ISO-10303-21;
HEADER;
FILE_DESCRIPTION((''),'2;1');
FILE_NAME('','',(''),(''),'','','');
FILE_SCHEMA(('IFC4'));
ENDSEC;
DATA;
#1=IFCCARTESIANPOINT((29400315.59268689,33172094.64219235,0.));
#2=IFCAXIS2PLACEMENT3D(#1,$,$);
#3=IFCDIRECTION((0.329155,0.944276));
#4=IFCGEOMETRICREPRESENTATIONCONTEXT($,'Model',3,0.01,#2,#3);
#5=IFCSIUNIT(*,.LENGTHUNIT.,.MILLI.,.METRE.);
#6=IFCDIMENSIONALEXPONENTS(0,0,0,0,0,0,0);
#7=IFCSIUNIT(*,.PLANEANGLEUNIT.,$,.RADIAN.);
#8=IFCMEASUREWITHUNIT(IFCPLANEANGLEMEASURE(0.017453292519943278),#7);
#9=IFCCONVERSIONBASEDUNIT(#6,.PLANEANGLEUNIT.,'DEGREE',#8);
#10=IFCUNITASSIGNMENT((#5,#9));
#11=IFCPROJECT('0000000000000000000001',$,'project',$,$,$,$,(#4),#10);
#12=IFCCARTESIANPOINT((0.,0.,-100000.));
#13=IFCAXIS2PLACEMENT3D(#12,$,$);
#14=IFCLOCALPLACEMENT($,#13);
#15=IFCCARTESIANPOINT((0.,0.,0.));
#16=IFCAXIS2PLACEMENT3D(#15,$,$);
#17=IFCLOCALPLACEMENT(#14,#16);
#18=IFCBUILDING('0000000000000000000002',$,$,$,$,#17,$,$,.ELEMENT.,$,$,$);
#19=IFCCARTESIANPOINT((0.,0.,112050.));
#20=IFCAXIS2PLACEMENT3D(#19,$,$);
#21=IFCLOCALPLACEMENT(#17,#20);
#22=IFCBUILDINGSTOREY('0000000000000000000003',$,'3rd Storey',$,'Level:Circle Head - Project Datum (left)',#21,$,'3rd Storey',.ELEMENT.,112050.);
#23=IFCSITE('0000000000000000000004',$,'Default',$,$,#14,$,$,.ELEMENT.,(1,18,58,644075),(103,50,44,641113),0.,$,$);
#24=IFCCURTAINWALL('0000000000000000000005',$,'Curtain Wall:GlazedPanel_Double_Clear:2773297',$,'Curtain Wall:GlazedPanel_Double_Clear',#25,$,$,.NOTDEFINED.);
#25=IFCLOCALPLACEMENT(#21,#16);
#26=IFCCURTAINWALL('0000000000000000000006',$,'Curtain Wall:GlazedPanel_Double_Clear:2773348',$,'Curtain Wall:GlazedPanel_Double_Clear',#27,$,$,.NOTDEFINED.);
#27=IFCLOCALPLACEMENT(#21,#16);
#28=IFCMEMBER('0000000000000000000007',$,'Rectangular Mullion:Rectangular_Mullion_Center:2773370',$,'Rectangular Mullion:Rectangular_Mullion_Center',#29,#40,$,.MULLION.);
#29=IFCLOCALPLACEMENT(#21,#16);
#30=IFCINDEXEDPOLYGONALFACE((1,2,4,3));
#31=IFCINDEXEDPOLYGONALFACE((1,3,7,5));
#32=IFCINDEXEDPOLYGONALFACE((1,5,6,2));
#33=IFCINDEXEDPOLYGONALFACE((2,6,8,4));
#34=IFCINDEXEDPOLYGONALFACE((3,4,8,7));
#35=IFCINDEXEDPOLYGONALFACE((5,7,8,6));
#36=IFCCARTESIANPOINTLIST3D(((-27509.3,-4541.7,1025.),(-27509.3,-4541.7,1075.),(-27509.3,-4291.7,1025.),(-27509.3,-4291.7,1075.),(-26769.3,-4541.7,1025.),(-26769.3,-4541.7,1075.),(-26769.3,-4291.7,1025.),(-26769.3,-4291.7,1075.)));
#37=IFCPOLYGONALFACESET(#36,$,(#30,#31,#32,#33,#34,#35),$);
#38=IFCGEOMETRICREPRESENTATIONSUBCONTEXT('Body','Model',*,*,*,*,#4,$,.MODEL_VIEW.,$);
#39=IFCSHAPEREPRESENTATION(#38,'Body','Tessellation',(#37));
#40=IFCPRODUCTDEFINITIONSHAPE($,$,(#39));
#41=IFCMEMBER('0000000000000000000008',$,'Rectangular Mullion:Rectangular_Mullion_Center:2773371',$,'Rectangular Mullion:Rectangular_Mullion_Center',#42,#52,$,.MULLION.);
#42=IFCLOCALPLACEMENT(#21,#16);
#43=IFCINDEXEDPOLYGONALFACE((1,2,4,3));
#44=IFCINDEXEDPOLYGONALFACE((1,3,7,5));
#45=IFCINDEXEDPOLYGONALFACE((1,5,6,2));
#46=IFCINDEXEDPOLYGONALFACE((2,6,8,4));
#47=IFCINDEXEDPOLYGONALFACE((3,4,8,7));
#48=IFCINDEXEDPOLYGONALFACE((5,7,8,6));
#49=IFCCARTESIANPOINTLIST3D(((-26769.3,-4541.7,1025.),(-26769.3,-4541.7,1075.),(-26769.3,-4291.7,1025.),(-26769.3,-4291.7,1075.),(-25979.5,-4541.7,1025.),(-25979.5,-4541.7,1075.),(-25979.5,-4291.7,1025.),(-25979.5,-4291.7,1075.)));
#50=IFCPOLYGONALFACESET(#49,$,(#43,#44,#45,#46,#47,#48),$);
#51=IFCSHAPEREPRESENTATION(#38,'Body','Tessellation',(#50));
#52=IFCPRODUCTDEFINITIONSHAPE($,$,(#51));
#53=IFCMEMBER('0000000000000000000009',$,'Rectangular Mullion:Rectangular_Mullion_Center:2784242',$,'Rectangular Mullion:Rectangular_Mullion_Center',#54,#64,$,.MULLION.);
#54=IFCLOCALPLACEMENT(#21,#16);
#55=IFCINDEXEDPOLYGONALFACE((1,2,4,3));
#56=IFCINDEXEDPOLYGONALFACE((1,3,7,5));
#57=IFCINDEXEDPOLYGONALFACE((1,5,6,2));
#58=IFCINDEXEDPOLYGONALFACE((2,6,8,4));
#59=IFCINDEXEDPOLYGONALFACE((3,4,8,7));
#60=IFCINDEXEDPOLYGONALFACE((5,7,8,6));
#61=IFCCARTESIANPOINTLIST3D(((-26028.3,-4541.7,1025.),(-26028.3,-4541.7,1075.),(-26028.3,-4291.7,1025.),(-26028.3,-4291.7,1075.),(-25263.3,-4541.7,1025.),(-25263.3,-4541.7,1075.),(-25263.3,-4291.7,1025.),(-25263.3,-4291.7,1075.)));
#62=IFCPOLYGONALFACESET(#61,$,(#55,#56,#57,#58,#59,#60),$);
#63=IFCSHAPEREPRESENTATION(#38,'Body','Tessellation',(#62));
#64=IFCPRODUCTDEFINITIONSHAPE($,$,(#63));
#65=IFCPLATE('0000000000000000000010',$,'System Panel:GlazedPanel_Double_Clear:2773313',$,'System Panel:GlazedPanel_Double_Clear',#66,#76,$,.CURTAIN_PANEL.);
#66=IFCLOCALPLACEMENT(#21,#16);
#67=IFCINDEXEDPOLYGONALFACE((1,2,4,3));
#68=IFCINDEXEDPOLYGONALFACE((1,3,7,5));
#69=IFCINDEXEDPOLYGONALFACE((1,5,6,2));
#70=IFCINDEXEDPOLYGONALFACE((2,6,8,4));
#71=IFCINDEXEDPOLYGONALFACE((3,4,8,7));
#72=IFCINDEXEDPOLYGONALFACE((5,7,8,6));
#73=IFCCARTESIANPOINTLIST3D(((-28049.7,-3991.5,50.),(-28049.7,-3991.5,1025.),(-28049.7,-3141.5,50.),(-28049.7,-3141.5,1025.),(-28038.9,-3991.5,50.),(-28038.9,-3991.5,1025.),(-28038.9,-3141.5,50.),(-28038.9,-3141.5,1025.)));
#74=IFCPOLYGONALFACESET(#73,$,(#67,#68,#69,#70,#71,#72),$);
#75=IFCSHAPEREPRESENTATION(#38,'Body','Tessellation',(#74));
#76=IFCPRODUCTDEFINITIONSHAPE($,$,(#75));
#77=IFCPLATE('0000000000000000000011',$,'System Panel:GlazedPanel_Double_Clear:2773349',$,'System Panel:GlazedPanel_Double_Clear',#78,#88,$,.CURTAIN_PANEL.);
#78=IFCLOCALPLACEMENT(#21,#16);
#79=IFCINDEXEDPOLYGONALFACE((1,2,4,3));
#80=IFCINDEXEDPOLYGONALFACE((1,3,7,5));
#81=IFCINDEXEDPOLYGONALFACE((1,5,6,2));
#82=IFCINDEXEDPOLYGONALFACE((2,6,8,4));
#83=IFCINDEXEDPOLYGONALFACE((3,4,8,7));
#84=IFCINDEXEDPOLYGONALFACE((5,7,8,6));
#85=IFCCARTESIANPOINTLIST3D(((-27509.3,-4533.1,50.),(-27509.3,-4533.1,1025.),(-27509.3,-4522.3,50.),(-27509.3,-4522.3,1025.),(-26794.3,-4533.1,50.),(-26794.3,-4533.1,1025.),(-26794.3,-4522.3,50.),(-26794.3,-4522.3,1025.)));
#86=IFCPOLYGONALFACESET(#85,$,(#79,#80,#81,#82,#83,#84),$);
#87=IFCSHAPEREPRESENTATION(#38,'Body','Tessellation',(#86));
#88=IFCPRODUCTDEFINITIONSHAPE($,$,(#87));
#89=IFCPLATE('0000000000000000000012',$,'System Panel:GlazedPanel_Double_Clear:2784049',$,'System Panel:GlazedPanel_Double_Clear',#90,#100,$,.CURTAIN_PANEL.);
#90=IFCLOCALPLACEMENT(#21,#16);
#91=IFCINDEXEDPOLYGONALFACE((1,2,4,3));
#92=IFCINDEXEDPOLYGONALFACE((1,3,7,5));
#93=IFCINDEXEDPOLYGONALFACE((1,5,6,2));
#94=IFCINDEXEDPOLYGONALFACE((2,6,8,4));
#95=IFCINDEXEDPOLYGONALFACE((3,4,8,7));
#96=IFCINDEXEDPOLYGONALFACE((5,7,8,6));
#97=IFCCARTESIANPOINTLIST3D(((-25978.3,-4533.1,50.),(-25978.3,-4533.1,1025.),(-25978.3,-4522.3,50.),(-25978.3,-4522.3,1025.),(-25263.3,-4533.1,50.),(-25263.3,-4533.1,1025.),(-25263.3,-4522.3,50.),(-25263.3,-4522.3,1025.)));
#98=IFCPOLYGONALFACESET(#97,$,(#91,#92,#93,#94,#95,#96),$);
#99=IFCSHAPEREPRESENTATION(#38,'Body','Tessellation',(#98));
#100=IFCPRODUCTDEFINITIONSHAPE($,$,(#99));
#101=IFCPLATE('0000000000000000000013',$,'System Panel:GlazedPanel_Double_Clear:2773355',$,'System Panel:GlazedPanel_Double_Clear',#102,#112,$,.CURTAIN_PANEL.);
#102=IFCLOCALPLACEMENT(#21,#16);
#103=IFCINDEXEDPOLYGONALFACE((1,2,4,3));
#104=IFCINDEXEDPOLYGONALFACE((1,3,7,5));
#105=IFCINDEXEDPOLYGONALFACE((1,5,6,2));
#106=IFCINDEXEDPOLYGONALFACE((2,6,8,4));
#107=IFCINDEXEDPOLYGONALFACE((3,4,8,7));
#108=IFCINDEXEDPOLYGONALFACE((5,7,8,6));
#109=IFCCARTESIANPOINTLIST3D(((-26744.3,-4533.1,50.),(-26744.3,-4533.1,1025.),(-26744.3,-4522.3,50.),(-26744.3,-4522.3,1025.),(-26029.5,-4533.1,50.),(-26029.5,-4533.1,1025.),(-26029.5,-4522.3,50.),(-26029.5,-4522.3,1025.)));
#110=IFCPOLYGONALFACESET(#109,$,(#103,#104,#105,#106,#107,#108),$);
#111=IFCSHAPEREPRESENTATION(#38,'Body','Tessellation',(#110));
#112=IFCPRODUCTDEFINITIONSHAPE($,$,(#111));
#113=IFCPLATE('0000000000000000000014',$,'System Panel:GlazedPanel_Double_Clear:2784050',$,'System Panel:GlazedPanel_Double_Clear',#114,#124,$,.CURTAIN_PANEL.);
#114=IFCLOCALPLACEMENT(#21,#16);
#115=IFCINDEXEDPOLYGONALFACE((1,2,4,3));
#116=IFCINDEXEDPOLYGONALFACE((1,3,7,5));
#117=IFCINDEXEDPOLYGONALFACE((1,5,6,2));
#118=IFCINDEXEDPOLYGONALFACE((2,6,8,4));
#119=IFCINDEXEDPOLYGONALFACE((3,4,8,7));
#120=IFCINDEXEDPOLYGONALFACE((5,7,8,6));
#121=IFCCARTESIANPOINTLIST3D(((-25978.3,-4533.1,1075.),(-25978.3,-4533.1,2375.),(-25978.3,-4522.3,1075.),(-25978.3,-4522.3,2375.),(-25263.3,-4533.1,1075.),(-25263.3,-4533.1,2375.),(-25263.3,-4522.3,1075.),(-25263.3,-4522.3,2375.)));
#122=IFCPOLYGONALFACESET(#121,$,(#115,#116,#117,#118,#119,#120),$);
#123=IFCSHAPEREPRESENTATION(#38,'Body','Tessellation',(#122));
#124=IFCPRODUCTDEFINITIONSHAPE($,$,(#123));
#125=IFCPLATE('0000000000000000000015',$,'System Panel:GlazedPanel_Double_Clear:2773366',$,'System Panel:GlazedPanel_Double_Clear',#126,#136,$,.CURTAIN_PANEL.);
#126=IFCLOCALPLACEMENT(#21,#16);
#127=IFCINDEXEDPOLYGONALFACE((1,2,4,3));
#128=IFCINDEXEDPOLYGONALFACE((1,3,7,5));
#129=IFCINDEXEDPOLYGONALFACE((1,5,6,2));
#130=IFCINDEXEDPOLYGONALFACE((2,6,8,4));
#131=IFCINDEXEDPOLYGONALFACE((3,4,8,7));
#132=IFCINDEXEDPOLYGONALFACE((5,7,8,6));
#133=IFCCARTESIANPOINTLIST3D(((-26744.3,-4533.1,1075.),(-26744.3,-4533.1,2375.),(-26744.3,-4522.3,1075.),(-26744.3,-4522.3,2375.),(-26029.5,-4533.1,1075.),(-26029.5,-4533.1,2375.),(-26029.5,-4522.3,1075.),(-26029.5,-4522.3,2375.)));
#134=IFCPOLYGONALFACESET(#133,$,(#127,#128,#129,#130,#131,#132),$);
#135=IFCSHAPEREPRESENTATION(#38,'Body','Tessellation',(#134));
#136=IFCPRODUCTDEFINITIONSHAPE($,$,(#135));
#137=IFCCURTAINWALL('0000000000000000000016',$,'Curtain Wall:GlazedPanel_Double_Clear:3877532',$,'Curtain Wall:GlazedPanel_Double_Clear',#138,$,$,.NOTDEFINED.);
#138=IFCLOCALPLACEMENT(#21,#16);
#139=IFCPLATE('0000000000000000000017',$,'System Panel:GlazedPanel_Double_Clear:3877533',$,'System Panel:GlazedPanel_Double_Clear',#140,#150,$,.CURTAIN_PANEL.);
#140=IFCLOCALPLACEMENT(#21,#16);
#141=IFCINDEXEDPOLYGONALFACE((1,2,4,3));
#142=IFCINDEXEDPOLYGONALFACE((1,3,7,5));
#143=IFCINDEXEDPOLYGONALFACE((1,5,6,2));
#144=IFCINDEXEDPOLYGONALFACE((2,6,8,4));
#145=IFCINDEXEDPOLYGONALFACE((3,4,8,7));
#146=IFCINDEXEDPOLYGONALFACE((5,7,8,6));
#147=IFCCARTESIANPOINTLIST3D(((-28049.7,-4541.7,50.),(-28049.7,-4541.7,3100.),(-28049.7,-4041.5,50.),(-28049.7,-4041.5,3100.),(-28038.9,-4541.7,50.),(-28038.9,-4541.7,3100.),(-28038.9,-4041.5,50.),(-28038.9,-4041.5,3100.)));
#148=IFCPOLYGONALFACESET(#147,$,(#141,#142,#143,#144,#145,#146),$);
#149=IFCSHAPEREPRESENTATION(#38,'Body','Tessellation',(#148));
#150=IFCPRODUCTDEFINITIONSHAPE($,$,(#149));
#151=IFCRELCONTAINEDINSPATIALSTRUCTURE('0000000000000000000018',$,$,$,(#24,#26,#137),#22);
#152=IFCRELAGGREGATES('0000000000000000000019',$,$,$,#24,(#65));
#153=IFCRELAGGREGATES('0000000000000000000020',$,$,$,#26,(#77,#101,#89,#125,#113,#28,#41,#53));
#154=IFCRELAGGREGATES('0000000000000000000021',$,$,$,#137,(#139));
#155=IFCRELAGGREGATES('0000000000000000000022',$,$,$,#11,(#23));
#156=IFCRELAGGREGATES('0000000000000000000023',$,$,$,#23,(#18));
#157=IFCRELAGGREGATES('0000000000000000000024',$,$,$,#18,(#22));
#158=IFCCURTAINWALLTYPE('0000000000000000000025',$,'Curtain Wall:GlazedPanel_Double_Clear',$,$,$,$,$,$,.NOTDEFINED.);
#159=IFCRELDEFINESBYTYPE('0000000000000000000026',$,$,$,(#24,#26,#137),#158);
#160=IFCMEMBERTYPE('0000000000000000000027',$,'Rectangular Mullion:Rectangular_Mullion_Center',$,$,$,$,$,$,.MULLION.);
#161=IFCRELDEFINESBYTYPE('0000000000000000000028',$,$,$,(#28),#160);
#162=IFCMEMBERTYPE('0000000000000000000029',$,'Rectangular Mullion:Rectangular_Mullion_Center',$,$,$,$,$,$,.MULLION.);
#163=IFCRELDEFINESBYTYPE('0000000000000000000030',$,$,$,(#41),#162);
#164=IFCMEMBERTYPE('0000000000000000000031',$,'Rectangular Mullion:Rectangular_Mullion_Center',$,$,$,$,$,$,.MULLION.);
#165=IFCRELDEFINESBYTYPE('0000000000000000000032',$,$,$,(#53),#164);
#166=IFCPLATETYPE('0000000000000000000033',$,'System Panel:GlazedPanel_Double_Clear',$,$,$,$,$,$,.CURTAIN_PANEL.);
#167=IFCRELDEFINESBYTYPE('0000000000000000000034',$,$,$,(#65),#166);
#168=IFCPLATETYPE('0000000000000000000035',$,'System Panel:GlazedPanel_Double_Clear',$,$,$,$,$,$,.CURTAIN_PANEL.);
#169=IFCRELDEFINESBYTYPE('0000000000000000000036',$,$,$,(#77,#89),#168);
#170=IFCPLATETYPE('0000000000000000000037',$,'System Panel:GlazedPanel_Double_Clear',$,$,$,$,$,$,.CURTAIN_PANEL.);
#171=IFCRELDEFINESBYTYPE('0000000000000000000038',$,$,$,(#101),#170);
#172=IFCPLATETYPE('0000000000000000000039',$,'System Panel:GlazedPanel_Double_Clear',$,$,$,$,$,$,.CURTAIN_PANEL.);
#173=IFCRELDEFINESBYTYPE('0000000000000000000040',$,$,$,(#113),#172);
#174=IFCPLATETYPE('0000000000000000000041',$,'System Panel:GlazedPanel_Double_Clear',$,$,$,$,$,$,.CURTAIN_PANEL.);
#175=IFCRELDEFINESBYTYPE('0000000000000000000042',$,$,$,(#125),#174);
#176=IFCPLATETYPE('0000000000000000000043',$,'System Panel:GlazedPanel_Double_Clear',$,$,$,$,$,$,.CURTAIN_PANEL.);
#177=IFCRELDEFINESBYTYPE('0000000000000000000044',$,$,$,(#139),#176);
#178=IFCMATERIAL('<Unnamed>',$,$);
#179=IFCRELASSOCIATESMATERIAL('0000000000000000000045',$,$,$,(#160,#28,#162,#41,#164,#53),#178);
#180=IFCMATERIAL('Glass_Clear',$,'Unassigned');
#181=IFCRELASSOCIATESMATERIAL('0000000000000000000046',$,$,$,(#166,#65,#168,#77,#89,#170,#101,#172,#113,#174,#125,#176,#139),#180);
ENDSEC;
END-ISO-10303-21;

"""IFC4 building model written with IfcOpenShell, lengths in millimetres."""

from ifc_helpers import new_model, entity, si_unit, converted_unit, direction, frame, origin, place, context, subcontext, project, spatial, indexed_curve, outline, extrude, source, transform, mapped, material, type_object, type_shapes, element, aggregate, save


model = new_model("IFC4")

# Units and contexts
model_context = context("Model", 3, precision=0.01, world=frame((29400315.59268689, 33172094.64219235, 0.0)), true_north=direction((0.329155, 0.944276)))
body_context = subcontext(model_context, "Body", "Model", "MODEL_VIEW")
ifc_project = project(units=[si_unit("LENGTHUNIT", "METRE", prefix="MILLI"), converted_unit("PLANEANGLEUNIT", "DEGREE", entity("IfcPlaneAngleMeasure", 0.017453292519943278), si_unit("PLANEANGLEUNIT", "RADIAN"), dimensions=[0, 0, 0, 0, 0, 0, 0])], contexts=[model_context])

# Site, building, storey
site_placement = place(None, frame((0.0, 0.0, -100000.0)))
site = spatial("IfcSite", under=ifc_project, at=site_placement, Name="Default", CompositionType="ELEMENT", RefLatitude=(1, 18, 58, 644075), RefLongitude=(103, 50, 44, 641113), RefElevation=0.0)
building_placement = place(site_placement, origin())
building = spatial("IfcBuilding", under=site, at=building_placement, CompositionType="ELEMENT")
storey_placement = place(building_placement, frame((0.0, 0.0, 112050.0)))
storey = spatial("IfcBuildingStorey", under=building, at=storey_placement, Name="3rd Storey", ObjectType="Level:Circle Head - Project Datum (left)", LongName="3rd Storey", CompositionType="ELEMENT", Elevation=112050.0)

# Curtain walls
curtain_wall_type = type_object("IfcCurtainWallType", Name="Curtain Wall:GlazedPanel_Double_Clear", PredefinedType="NOTDEFINED")
curtain_wall_1_placement = place(storey_placement, frame((0.0, 0.0, -112050.0)))
curtain_wall_1 = element("IfcCurtainWall", 1, at=curtain_wall_1_placement, inside=storey, type_object=curtain_wall_type, Name="Curtain Wall:GlazedPanel_Double_Clear:2773297", ObjectType="Curtain Wall:GlazedPanel_Double_Clear", PredefinedType="NOTDEFINED")
ifc_material_1 = material(Name="<Unnamed>")
curtain_wall_2_placement = place(storey_placement, frame((0.0, 0.0, -112050.0)))
curtain_wall_2 = element("IfcCurtainWall", 2, at=curtain_wall_2_placement, inside=storey, type_object=curtain_wall_type, Name="Curtain Wall:GlazedPanel_Double_Clear:2773348", ObjectType="Curtain Wall:GlazedPanel_Double_Clear", PredefinedType="NOTDEFINED")

# Members
member_type_1 = type_object("IfcMemberType", Name="Rectangular Mullion:Rectangular_Mullion_Center", PredefinedType="MULLION", material=ifc_material_1)
shared_shape_1 = source(origin(), body_context, "Body", "SweptSolid", [
    extrude(outline(indexed_curve([(-25.0, -125.0), (25.0, -125.0), (25.0, 125.0), (-25.0, 125.0), (-25.0, -125.0)], self_intersect=False)), frame((0.0, 0.0, -740.0), z_axis=(0.0, 0.0, 1.0), x_axis=(-1.0, 0.0, 0.0)), (0.0, 0.0, 1.0), 740.0),
])
type_shapes(member_type_1, [shared_shape_1])
member_1_placement = place(curtain_wall_2_placement, frame((-26769.3, -4416.7, 113100.0), z_axis=(1.0, 0.0, 0.0), x_axis=(0.0, 0.0, 1.0)))
member_1 = element("IfcMember", 3, at=member_1_placement, type_object=member_type_1, material=ifc_material_1, Name="Rectangular Mullion:Rectangular_Mullion_Center:2773370", ObjectType="Rectangular Mullion:Rectangular_Mullion_Center", PredefinedType="MULLION", context=body_context, shape_type="MappedRepresentation", body=[
    mapped(shared_shape_1, transform((0.0, 0.0, 0.0), scale=1.0)),
])
member_type_2 = type_object("IfcMemberType", Name="Rectangular Mullion:Rectangular_Mullion_Center", PredefinedType="MULLION", material=ifc_material_1)
shared_shape_2 = source(origin(), body_context, "Body", "SweptSolid", [
    extrude(outline(indexed_curve([(-25.0, -125.0), (25.0, -125.0), (25.0, 125.0), (-25.0, 125.0), (-25.0, -125.0)], self_intersect=False)), frame((0.0, 0.0, -789.8), z_axis=(0.0, 0.0, 1.0), x_axis=(-1.0, 0.0, 0.0)), (0.0, 0.0, 1.0), 789.8),
])
type_shapes(member_type_2, [shared_shape_2])
member_2_placement = place(curtain_wall_2_placement, frame((-25979.5, -4416.7, 113100.0), z_axis=(1.0, 0.0, 0.0), x_axis=(0.0, 0.0, 1.0)))
member_2 = element("IfcMember", 4, at=member_2_placement, type_object=member_type_2, material=ifc_material_1, Name="Rectangular Mullion:Rectangular_Mullion_Center:2773371", ObjectType="Rectangular Mullion:Rectangular_Mullion_Center", PredefinedType="MULLION", context=body_context, shape_type="MappedRepresentation", body=[
    mapped(shared_shape_2, transform((0.0, 0.0, 0.0), scale=1.0)),
])
member_type_3 = type_object("IfcMemberType", Name="Rectangular Mullion:Rectangular_Mullion_Center", PredefinedType="MULLION", material=ifc_material_1)
shared_shape_3 = source(origin(), body_context, "Body", "SweptSolid", [
    extrude(outline(indexed_curve([(-25.0, -125.0), (25.0, -125.0), (25.0, 125.0), (-25.0, 125.0), (-25.0, -125.0)], self_intersect=False)), frame((0.0, 0.0, -765.0), z_axis=(0.0, 0.0, 1.0), x_axis=(-1.0, 0.0, 0.0)), (0.0, 0.0, 1.0), 765.0),
])
type_shapes(member_type_3, [shared_shape_3])
member_3_placement = place(curtain_wall_2_placement, frame((-25263.3, -4416.7, 113100.0), z_axis=(1.0, 0.0, 0.0), x_axis=(0.0, 0.0, 1.0)))
member_3 = element("IfcMember", 5, at=member_3_placement, type_object=member_type_3, material=ifc_material_1, Name="Rectangular Mullion:Rectangular_Mullion_Center:2784242", ObjectType="Rectangular Mullion:Rectangular_Mullion_Center", PredefinedType="MULLION", context=body_context, shape_type="MappedRepresentation", body=[
    mapped(shared_shape_3, transform((0.0, 0.0, 0.0), scale=1.0)),
])

# Plates
ifc_material_2 = material(Name="Glass_Clear", Category="Unassigned")
plate_type_1 = type_object("IfcPlateType", Name="System Panel:GlazedPanel_Double_Clear", PredefinedType="CURTAIN_PANEL", material=ifc_material_2)
shared_shape_4 = source(origin(), body_context, "Body", "SweptSolid", [
    extrude(outline(indexed_curve([(-5.4, -425.0), (5.4, -425.0), (5.4, 425.0), (-5.4, 425.0), (-5.4, -425.0)], self_intersect=False)), frame((0.0, -111.0, 0.0), z_axis=(0.0, 0.0, 1.0), x_axis=(0.0, 1.0, 0.0)), (0.0, 0.0, 1.0), 975.0),
])
type_shapes(plate_type_1, [shared_shape_4])
plate_1_placement = place(curtain_wall_1_placement, frame((-27933.3, -3566.5, 112100.0), z_axis=(0.0, 0.0, 1.0), x_axis=(0.0, -1.0, 0.0)))
plate_1 = element("IfcPlate", 6, at=plate_1_placement, type_object=plate_type_1, material=ifc_material_2, Name="System Panel:GlazedPanel_Double_Clear:2773313", ObjectType="System Panel:GlazedPanel_Double_Clear", PredefinedType="CURTAIN_PANEL", context=body_context, shape_type="MappedRepresentation", body=[
    mapped(shared_shape_4, transform((0.0, 0.0, 0.0), scale=1.0)),
])
aggregate(curtain_wall_1, [plate_1])
plate_type_2 = type_object("IfcPlateType", Name="System Panel:GlazedPanel_Double_Clear", PredefinedType="CURTAIN_PANEL", material=ifc_material_2)
shared_shape_5 = source(origin(), body_context, "Body", "SweptSolid", [
    extrude(outline(indexed_curve([(-5.4, -357.5), (5.4, -357.5), (5.4, 357.5), (-5.4, 357.5), (-5.4, -357.5)], self_intersect=False)), frame((0.0, -111.0, 0.0), z_axis=(0.0, 0.0, 1.0), x_axis=(0.0, 1.0, 0.0)), (0.0, 0.0, 1.0), 975.0),
])
type_shapes(plate_type_2, [shared_shape_5])
plate_2_placement = place(curtain_wall_2_placement, frame((-27151.8, -4416.7, 112100.0)))
plate_2 = element("IfcPlate", 7, at=plate_2_placement, type_object=plate_type_2, material=ifc_material_2, Name="System Panel:GlazedPanel_Double_Clear:2773349", ObjectType="System Panel:GlazedPanel_Double_Clear", PredefinedType="CURTAIN_PANEL", context=body_context, shape_type="MappedRepresentation", body=[
    mapped(shared_shape_5, transform((0.0, 0.0, 0.0), scale=1.0)),
])
plate_3_placement = place(curtain_wall_2_placement, frame((-25620.8, -4416.7, 112100.0)))
plate_3 = element("IfcPlate", 8, at=plate_3_placement, type_object=plate_type_2, material=ifc_material_2, Name="System Panel:GlazedPanel_Double_Clear:2784049", ObjectType="System Panel:GlazedPanel_Double_Clear", PredefinedType="CURTAIN_PANEL", context=body_context, shape_type="MappedRepresentation", body=[
    mapped(shared_shape_5, transform((0.0, 0.0, 0.0), scale=1.0)),
])
plate_type_3 = type_object("IfcPlateType", Name="System Panel:GlazedPanel_Double_Clear", PredefinedType="CURTAIN_PANEL", material=ifc_material_2)
shared_shape_6 = source(origin(), body_context, "Body", "SweptSolid", [
    extrude(outline(indexed_curve([(-5.4, -357.4), (5.4, -357.4), (5.4, 357.4), (-5.4, 357.4), (-5.4, -357.4)], self_intersect=False)), frame((0.0, -111.0, 0.0), z_axis=(0.0, 0.0, 1.0), x_axis=(0.0, 1.0, 0.0)), (0.0, 0.0, 1.0), 975.0),
])
type_shapes(plate_type_3, [shared_shape_6])
plate_4_placement = place(curtain_wall_2_placement, frame((-26386.9, -4416.7, 112100.0)))
plate_4 = element("IfcPlate", 9, at=plate_4_placement, type_object=plate_type_3, material=ifc_material_2, Name="System Panel:GlazedPanel_Double_Clear:2773355", ObjectType="System Panel:GlazedPanel_Double_Clear", PredefinedType="CURTAIN_PANEL", context=body_context, shape_type="MappedRepresentation", body=[
    mapped(shared_shape_6, transform((0.0, 0.0, 0.0), scale=1.0)),
])
plate_type_4 = type_object("IfcPlateType", Name="System Panel:GlazedPanel_Double_Clear", PredefinedType="CURTAIN_PANEL", material=ifc_material_2)
shared_shape_7 = source(origin(), body_context, "Body", "SweptSolid", [
    extrude(outline(indexed_curve([(-5.4, -357.5), (5.4, -357.5), (5.4, 357.5), (-5.4, 357.5), (-5.4, -357.5)], self_intersect=False)), frame((0.0, -111.0, 0.0), z_axis=(0.0, 0.0, 1.0), x_axis=(0.0, 1.0, 0.0)), (0.0, 0.0, 1.0), 1300.0),
])
type_shapes(plate_type_4, [shared_shape_7])
plate_5_placement = place(curtain_wall_2_placement, frame((-25620.8, -4416.7, 113125.0)))
plate_5 = element("IfcPlate", 10, at=plate_5_placement, type_object=plate_type_4, material=ifc_material_2, Name="System Panel:GlazedPanel_Double_Clear:2784050", ObjectType="System Panel:GlazedPanel_Double_Clear", PredefinedType="CURTAIN_PANEL", context=body_context, shape_type="MappedRepresentation", body=[
    mapped(shared_shape_7, transform((0.0, 0.0, 0.0), scale=1.0)),
])
plate_type_5 = type_object("IfcPlateType", Name="System Panel:GlazedPanel_Double_Clear", PredefinedType="CURTAIN_PANEL", material=ifc_material_2)
shared_shape_8 = source(origin(), body_context, "Body", "SweptSolid", [
    extrude(outline(indexed_curve([(-5.4, -357.4), (5.4, -357.4), (5.4, 357.4), (-5.4, 357.4), (-5.4, -357.4)], self_intersect=False)), frame((0.0, -111.0, 0.0), z_axis=(0.0, 0.0, 1.0), x_axis=(0.0, 1.0, 0.0)), (0.0, 0.0, 1.0), 1300.0),
])
type_shapes(plate_type_5, [shared_shape_8])
plate_6_placement = place(curtain_wall_2_placement, frame((-26386.9, -4416.7, 113125.0)))
plate_6 = element("IfcPlate", 11, at=plate_6_placement, type_object=plate_type_5, material=ifc_material_2, Name="System Panel:GlazedPanel_Double_Clear:2773366", ObjectType="System Panel:GlazedPanel_Double_Clear", PredefinedType="CURTAIN_PANEL", context=body_context, shape_type="MappedRepresentation", body=[
    mapped(shared_shape_8, transform((0.0, 0.0, 0.0), scale=1.0)),
])
aggregate(curtain_wall_2, [plate_2, plate_4, plate_3, plate_6, plate_5, member_1, member_2, member_3])

# Curtain wall, plate
curtain_wall_3_placement = place(storey_placement, frame((0.0, 0.0, -112050.0)))
curtain_wall_3 = element("IfcCurtainWall", 12, at=curtain_wall_3_placement, inside=storey, type_object=curtain_wall_type, Name="Curtain Wall:GlazedPanel_Double_Clear:3877532", ObjectType="Curtain Wall:GlazedPanel_Double_Clear", PredefinedType="NOTDEFINED")
plate_type_6 = type_object("IfcPlateType", Name="System Panel:GlazedPanel_Double_Clear", PredefinedType="CURTAIN_PANEL", material=ifc_material_2)
shared_shape_9 = source(origin(), body_context, "Body", "SweptSolid", [
    extrude(outline(indexed_curve([(-5.4, -250.1), (5.4, -250.1), (5.4, 250.1), (-5.4, 250.1), (-5.4, -250.1)], self_intersect=False)), frame((0.0, -111.0, 0.0), z_axis=(0.0, 0.0, 1.0), x_axis=(0.0, 1.0, 0.0)), (0.0, 0.0, 1.0), 3050.0),
])
type_shapes(plate_type_6, [shared_shape_9])
plate_7_placement = place(curtain_wall_3_placement, frame((-27933.3, -4291.6, 112100.0), z_axis=(0.0, 0.0, 1.0), x_axis=(0.0, -1.0, 0.0)))
plate_7 = element("IfcPlate", 13, at=plate_7_placement, type_object=plate_type_6, material=ifc_material_2, Name="System Panel:GlazedPanel_Double_Clear:3877533", ObjectType="System Panel:GlazedPanel_Double_Clear", PredefinedType="CURTAIN_PANEL", context=body_context, shape_type="MappedRepresentation", body=[
    mapped(shared_shape_9, transform((0.0, 0.0, 0.0), scale=1.0)),
])
aggregate(curtain_wall_3, [plate_7])

save(model, "model.ifc")
